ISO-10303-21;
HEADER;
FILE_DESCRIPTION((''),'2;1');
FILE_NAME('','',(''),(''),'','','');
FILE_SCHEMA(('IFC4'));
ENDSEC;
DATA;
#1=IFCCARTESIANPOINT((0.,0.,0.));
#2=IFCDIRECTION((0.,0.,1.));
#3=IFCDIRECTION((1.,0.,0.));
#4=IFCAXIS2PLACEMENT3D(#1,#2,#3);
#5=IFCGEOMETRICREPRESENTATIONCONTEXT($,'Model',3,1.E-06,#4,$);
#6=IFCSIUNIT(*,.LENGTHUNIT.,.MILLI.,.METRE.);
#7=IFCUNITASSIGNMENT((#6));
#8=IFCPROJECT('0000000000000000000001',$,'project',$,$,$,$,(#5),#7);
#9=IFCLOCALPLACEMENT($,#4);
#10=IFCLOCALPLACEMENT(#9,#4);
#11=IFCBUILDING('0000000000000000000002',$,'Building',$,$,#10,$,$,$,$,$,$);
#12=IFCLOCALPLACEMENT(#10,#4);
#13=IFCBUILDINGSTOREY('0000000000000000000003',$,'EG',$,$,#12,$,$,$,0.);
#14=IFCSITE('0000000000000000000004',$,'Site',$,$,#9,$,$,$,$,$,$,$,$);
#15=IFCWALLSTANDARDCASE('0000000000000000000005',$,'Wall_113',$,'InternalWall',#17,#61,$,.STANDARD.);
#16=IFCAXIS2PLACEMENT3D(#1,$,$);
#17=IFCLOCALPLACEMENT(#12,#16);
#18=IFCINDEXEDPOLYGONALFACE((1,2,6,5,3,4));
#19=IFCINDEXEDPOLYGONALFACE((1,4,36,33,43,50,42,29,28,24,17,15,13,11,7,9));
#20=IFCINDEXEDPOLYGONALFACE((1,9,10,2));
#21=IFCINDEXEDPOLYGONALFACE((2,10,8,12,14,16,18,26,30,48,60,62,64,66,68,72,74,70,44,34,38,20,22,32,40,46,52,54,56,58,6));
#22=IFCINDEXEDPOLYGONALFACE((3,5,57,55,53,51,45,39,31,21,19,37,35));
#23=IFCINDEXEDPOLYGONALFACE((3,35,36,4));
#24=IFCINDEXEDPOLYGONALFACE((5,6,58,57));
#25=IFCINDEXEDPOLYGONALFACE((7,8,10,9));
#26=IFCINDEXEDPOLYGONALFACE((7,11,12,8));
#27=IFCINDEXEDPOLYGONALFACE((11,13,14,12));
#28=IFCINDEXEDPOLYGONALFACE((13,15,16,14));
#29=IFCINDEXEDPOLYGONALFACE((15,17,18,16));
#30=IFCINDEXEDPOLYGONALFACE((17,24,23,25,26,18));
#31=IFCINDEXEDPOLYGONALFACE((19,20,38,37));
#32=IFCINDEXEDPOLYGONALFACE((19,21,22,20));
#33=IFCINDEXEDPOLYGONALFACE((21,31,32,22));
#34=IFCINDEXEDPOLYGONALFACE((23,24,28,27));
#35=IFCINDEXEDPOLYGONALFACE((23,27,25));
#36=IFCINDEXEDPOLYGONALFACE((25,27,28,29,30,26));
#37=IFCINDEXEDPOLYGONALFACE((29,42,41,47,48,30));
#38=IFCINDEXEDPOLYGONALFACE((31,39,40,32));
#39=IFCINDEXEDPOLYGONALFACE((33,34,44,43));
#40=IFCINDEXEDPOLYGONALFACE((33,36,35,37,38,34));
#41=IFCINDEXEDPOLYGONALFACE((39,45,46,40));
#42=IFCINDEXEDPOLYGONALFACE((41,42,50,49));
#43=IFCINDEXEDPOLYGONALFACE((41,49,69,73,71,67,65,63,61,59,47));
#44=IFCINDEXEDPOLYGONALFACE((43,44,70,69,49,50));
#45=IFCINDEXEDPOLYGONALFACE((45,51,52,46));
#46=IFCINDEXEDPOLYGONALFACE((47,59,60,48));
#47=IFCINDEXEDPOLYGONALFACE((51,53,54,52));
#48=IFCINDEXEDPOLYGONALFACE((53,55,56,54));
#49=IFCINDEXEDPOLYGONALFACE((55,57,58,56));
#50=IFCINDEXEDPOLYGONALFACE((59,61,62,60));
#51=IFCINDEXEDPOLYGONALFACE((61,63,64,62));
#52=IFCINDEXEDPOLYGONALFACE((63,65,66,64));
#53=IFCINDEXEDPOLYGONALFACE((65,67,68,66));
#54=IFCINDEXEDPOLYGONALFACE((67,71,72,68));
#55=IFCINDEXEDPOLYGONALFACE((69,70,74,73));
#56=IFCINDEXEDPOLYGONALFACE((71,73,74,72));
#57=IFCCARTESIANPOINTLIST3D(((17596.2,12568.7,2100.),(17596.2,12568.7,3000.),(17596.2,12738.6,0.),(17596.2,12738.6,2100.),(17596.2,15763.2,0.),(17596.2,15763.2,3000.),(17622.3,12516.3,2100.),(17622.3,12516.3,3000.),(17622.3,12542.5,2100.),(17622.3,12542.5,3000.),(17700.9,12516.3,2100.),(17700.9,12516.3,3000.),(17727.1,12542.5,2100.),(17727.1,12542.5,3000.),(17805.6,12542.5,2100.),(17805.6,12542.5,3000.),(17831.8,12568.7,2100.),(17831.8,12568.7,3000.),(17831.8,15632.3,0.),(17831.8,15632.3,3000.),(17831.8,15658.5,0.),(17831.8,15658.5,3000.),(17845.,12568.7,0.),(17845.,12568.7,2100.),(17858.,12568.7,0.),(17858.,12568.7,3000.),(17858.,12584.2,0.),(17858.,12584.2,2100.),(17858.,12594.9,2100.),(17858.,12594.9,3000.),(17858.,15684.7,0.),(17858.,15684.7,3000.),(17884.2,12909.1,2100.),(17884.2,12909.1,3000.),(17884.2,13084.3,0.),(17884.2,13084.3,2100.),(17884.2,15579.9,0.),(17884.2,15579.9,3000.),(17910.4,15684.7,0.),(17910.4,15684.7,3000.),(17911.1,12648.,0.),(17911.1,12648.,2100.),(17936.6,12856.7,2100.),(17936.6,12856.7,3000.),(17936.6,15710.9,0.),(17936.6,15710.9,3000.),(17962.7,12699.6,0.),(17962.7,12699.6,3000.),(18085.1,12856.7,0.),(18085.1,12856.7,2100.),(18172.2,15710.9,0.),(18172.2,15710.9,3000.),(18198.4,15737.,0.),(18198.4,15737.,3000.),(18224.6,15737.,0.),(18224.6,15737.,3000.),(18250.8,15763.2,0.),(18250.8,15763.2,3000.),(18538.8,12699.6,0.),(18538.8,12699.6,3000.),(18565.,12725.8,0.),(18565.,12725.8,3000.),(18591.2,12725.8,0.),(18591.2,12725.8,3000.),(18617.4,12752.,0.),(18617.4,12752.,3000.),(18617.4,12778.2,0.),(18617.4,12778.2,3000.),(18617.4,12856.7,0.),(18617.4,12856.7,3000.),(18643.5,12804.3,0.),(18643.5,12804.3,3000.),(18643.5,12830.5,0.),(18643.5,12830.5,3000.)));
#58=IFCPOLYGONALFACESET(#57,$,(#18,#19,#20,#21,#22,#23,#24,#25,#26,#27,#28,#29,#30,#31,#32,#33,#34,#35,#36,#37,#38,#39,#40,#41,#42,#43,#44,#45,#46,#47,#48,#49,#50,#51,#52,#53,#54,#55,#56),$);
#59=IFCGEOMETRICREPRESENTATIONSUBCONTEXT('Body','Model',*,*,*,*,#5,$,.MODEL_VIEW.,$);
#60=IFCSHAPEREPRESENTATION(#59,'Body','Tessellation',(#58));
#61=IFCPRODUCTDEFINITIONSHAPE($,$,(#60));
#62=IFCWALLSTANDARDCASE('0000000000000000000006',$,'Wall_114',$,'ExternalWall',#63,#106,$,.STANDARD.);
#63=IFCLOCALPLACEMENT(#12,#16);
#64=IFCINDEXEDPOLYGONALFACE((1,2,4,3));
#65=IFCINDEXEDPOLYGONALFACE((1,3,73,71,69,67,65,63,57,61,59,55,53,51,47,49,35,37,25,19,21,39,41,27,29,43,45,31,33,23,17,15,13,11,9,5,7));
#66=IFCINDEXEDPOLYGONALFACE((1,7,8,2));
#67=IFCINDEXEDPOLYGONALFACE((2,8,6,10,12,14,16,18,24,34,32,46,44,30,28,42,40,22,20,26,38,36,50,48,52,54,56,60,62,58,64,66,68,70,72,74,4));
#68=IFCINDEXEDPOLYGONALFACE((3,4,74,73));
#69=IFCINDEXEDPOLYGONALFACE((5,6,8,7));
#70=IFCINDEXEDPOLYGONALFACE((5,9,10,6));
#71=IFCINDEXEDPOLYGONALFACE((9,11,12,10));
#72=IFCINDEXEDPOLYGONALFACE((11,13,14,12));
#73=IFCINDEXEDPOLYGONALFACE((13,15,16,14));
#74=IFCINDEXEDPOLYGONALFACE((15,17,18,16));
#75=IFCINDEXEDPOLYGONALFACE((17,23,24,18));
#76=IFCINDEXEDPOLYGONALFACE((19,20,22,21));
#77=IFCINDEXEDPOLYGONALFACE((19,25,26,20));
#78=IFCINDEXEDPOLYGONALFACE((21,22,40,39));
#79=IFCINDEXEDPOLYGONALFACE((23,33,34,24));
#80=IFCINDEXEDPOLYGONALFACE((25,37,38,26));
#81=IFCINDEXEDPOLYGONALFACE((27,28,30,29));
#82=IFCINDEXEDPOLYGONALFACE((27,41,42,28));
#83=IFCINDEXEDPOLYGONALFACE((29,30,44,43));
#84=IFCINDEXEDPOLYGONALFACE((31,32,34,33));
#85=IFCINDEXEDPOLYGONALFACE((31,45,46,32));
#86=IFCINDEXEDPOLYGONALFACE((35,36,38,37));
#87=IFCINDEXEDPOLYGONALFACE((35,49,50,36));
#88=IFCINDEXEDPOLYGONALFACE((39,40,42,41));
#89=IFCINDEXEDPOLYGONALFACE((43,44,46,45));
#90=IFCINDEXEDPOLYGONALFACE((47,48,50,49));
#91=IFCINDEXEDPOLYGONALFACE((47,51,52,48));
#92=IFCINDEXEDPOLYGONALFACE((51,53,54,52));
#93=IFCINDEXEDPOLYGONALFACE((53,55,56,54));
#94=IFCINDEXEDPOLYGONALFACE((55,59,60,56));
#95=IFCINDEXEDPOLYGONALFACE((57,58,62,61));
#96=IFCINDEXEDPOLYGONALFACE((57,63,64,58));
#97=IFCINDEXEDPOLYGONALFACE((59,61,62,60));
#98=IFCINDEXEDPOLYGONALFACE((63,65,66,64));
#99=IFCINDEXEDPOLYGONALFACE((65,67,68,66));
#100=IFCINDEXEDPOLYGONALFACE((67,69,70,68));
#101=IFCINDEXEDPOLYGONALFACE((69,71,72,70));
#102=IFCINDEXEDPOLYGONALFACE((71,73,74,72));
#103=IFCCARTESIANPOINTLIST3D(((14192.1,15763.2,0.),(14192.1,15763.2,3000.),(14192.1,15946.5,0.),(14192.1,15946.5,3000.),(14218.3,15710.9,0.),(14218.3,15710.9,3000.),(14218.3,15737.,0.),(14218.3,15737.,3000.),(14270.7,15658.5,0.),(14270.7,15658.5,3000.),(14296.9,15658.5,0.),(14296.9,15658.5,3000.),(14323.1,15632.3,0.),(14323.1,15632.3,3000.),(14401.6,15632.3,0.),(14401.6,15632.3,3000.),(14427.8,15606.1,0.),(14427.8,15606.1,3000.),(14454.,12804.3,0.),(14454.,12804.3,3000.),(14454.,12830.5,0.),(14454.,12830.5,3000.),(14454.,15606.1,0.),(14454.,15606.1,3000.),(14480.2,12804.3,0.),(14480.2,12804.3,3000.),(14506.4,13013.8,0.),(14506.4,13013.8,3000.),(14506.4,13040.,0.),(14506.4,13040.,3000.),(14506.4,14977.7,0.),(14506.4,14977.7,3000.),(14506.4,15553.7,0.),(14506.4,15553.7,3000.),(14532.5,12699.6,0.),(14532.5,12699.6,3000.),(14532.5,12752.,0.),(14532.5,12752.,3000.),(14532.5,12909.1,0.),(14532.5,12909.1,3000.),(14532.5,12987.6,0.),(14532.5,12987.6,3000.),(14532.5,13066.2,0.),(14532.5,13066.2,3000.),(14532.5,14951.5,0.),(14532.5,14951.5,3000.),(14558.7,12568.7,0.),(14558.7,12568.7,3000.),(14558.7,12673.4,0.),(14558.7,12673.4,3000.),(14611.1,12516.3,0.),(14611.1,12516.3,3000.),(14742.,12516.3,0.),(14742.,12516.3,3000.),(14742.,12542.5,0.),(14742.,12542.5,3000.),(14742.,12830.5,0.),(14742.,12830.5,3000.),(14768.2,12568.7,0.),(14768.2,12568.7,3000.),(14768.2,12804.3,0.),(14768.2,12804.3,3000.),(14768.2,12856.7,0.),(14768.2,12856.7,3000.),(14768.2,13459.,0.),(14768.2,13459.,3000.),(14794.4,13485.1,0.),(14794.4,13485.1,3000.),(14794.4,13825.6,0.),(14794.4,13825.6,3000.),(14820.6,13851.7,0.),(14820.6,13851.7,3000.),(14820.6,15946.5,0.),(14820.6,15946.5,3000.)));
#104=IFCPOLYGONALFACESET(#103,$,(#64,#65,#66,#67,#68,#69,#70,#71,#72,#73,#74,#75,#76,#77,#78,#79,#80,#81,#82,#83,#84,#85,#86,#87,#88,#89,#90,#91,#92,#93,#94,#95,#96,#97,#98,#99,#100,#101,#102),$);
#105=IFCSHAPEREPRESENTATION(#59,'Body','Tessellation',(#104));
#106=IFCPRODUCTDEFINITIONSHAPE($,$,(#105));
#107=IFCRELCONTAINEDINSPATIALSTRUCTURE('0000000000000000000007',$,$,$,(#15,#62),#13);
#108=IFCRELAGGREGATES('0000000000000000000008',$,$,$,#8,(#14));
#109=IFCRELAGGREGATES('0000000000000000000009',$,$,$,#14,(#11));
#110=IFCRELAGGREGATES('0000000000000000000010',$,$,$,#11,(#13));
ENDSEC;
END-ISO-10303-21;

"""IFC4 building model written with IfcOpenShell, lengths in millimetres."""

from ifc_helpers import new_model, si_unit, frame, origin_with_axes, place, context, subcontext, project, spatial, polyline, rectangle, outline, extrude, element, save


model = new_model("IFC4")

# Units and contexts
model_context = context("Model", 3, precision=1e-06, world=origin_with_axes())
body_context = subcontext(model_context, "Body", "Model", "MODEL_VIEW")
ifc_project = project(units=[si_unit("LENGTHUNIT", "METRE", prefix="MILLI")], contexts=[model_context])

# Site, building, storey
site_placement = place(None, origin_with_axes())
site = spatial("IfcSite", under=ifc_project, at=site_placement, Name="Site")
building_placement = place(site_placement, origin_with_axes())
building = spatial("IfcBuilding", under=site, at=building_placement, Name="Building")
storey_placement = place(building_placement, origin_with_axes())
storey = spatial("IfcBuildingStorey", under=building, at=storey_placement, Name="EG", Elevation=0.0)

# Wall, opening
wall_1_placement = place(storey_placement, origin_with_axes())
wall_1 = element("IfcWallStandardCase", 1, at=wall_1_placement, inside=storey, Name="Wall_113", ObjectType="InternalWall", PredefinedType="STANDARD", context=body_context, shape_type="SweptSolid", body=[
    extrude(outline(polyline([(17622.3, 12516.3, 0.0), (17622.3, 12542.5, 0.0), (17596.2, 12568.7, 0.0), (17596.2, 15763.2, 0.0), (18250.8, 15763.2, 0.0), (18224.6, 15737.0, 0.0), (18198.4, 15737.0, 0.0), (18172.2, 15710.9, 0.0), (17936.6, 15710.9, 0.0), (17910.4, 15684.7, 0.0), (17858.0, 15684.7, 0.0), (17831.8, 15658.5, 0.0), (17831.8, 15632.3, 0.0), (17884.2, 15579.9, 0.0), (17884.2, 12909.1, 0.0), (17936.6, 12856.7, 0.0), (18617.4, 12856.7, 0.0), (18643.5, 12830.5, 0.0), (18643.5, 12804.3, 0.0), (18617.4, 12778.2, 0.0), (18617.4, 12752.0, 0.0), (18591.2, 12725.8, 0.0), (18565.0, 12725.8, 0.0), (18538.8, 12699.6, 0.0), (17962.7, 12699.6, 0.0), (17858.0, 12594.9, 0.0), (17858.0, 12568.7, 0.0), (17831.8, 12568.7, 0.0), (17805.6, 12542.5, 0.0), (17727.1, 12542.5, 0.0), (17700.9, 12516.3, 0.0), (17622.3, 12516.3, 0.0)])), origin_with_axes(), (0.0, 0.0, 1.0), 3000.0),
])
opening_1_placement = place(wall_1_placement, origin_with_axes())
element("IfcOpeningElement", 2, at=opening_1_placement, inside=storey, cuts=wall_1, context=body_context, shape_type="SweptSolid", body=[
    extrude(rectangle(XDim=1424.9, YDim=300.0), frame((17585.9, 12492.1, 0.0), z_axis=(0.0, 0.0, 1.0), x_axis=(-0.640184, -0.768221, 0.0)), (0.0, 0.0, 1.0), 2100.0),
])

# Wall
for number, where, z_axis, x_axis, name in (
    (3, (0.0, 0.0, 0.0), (0.0, 0.0, 1.0), (1.0, 0.0, 0.0), "Wall_114"),
):
    element("IfcWallStandardCase", number, at=place(storey_placement, frame(where, z_axis=z_axis, x_axis=x_axis)), inside=storey, Name=name, ObjectType="ExternalWall", PredefinedType="STANDARD", context=body_context, shape_type="SweptSolid", body=[
        extrude(outline(polyline([(14611.1, 12516.3, 0.0), (14558.7, 12568.7, 0.0), (14558.7, 12673.4, 0.0), (14532.5, 12699.6, 0.0), (14532.5, 12752.0, 0.0), (14480.2, 12804.3, 0.0), (14454.0, 12804.3, 0.0), (14454.0, 12830.5, 0.0), (14532.5, 12909.1, 0.0), (14532.5, 12987.6, 0.0), (14506.4, 13013.8, 0.0), (14506.4, 13040.0, 0.0), (14532.5, 13066.2, 0.0), (14532.5, 14951.5, 0.0), (14506.4, 14977.7, 0.0), (14506.4, 15553.7, 0.0), (14454.0, 15606.1, 0.0), (14427.8, 15606.1, 0.0), (14401.6, 15632.3, 0.0), (14323.1, 15632.3, 0.0), (14296.9, 15658.5, 0.0), (14270.7, 15658.5, 0.0), (14218.3, 15710.9, 0.0), (14218.3, 15737.0, 0.0), (14192.1, 15763.2, 0.0), (14192.1, 15946.5, 0.0), (14820.6, 15946.5, 0.0), (14820.6, 13851.7, 0.0), (14794.4, 13825.6, 0.0), (14794.4, 13485.1, 0.0), (14768.2, 13459.0, 0.0), (14768.2, 12856.7, 0.0), (14742.0, 12830.5, 0.0), (14768.2, 12804.3, 0.0), (14768.2, 12568.7, 0.0), (14742.0, 12542.5, 0.0), (14742.0, 12516.3, 0.0), (14611.1, 12516.3, 0.0)])), origin_with_axes(), (0.0, 0.0, 1.0), 3000.0),
    ])

save(model, "model.ifc")
